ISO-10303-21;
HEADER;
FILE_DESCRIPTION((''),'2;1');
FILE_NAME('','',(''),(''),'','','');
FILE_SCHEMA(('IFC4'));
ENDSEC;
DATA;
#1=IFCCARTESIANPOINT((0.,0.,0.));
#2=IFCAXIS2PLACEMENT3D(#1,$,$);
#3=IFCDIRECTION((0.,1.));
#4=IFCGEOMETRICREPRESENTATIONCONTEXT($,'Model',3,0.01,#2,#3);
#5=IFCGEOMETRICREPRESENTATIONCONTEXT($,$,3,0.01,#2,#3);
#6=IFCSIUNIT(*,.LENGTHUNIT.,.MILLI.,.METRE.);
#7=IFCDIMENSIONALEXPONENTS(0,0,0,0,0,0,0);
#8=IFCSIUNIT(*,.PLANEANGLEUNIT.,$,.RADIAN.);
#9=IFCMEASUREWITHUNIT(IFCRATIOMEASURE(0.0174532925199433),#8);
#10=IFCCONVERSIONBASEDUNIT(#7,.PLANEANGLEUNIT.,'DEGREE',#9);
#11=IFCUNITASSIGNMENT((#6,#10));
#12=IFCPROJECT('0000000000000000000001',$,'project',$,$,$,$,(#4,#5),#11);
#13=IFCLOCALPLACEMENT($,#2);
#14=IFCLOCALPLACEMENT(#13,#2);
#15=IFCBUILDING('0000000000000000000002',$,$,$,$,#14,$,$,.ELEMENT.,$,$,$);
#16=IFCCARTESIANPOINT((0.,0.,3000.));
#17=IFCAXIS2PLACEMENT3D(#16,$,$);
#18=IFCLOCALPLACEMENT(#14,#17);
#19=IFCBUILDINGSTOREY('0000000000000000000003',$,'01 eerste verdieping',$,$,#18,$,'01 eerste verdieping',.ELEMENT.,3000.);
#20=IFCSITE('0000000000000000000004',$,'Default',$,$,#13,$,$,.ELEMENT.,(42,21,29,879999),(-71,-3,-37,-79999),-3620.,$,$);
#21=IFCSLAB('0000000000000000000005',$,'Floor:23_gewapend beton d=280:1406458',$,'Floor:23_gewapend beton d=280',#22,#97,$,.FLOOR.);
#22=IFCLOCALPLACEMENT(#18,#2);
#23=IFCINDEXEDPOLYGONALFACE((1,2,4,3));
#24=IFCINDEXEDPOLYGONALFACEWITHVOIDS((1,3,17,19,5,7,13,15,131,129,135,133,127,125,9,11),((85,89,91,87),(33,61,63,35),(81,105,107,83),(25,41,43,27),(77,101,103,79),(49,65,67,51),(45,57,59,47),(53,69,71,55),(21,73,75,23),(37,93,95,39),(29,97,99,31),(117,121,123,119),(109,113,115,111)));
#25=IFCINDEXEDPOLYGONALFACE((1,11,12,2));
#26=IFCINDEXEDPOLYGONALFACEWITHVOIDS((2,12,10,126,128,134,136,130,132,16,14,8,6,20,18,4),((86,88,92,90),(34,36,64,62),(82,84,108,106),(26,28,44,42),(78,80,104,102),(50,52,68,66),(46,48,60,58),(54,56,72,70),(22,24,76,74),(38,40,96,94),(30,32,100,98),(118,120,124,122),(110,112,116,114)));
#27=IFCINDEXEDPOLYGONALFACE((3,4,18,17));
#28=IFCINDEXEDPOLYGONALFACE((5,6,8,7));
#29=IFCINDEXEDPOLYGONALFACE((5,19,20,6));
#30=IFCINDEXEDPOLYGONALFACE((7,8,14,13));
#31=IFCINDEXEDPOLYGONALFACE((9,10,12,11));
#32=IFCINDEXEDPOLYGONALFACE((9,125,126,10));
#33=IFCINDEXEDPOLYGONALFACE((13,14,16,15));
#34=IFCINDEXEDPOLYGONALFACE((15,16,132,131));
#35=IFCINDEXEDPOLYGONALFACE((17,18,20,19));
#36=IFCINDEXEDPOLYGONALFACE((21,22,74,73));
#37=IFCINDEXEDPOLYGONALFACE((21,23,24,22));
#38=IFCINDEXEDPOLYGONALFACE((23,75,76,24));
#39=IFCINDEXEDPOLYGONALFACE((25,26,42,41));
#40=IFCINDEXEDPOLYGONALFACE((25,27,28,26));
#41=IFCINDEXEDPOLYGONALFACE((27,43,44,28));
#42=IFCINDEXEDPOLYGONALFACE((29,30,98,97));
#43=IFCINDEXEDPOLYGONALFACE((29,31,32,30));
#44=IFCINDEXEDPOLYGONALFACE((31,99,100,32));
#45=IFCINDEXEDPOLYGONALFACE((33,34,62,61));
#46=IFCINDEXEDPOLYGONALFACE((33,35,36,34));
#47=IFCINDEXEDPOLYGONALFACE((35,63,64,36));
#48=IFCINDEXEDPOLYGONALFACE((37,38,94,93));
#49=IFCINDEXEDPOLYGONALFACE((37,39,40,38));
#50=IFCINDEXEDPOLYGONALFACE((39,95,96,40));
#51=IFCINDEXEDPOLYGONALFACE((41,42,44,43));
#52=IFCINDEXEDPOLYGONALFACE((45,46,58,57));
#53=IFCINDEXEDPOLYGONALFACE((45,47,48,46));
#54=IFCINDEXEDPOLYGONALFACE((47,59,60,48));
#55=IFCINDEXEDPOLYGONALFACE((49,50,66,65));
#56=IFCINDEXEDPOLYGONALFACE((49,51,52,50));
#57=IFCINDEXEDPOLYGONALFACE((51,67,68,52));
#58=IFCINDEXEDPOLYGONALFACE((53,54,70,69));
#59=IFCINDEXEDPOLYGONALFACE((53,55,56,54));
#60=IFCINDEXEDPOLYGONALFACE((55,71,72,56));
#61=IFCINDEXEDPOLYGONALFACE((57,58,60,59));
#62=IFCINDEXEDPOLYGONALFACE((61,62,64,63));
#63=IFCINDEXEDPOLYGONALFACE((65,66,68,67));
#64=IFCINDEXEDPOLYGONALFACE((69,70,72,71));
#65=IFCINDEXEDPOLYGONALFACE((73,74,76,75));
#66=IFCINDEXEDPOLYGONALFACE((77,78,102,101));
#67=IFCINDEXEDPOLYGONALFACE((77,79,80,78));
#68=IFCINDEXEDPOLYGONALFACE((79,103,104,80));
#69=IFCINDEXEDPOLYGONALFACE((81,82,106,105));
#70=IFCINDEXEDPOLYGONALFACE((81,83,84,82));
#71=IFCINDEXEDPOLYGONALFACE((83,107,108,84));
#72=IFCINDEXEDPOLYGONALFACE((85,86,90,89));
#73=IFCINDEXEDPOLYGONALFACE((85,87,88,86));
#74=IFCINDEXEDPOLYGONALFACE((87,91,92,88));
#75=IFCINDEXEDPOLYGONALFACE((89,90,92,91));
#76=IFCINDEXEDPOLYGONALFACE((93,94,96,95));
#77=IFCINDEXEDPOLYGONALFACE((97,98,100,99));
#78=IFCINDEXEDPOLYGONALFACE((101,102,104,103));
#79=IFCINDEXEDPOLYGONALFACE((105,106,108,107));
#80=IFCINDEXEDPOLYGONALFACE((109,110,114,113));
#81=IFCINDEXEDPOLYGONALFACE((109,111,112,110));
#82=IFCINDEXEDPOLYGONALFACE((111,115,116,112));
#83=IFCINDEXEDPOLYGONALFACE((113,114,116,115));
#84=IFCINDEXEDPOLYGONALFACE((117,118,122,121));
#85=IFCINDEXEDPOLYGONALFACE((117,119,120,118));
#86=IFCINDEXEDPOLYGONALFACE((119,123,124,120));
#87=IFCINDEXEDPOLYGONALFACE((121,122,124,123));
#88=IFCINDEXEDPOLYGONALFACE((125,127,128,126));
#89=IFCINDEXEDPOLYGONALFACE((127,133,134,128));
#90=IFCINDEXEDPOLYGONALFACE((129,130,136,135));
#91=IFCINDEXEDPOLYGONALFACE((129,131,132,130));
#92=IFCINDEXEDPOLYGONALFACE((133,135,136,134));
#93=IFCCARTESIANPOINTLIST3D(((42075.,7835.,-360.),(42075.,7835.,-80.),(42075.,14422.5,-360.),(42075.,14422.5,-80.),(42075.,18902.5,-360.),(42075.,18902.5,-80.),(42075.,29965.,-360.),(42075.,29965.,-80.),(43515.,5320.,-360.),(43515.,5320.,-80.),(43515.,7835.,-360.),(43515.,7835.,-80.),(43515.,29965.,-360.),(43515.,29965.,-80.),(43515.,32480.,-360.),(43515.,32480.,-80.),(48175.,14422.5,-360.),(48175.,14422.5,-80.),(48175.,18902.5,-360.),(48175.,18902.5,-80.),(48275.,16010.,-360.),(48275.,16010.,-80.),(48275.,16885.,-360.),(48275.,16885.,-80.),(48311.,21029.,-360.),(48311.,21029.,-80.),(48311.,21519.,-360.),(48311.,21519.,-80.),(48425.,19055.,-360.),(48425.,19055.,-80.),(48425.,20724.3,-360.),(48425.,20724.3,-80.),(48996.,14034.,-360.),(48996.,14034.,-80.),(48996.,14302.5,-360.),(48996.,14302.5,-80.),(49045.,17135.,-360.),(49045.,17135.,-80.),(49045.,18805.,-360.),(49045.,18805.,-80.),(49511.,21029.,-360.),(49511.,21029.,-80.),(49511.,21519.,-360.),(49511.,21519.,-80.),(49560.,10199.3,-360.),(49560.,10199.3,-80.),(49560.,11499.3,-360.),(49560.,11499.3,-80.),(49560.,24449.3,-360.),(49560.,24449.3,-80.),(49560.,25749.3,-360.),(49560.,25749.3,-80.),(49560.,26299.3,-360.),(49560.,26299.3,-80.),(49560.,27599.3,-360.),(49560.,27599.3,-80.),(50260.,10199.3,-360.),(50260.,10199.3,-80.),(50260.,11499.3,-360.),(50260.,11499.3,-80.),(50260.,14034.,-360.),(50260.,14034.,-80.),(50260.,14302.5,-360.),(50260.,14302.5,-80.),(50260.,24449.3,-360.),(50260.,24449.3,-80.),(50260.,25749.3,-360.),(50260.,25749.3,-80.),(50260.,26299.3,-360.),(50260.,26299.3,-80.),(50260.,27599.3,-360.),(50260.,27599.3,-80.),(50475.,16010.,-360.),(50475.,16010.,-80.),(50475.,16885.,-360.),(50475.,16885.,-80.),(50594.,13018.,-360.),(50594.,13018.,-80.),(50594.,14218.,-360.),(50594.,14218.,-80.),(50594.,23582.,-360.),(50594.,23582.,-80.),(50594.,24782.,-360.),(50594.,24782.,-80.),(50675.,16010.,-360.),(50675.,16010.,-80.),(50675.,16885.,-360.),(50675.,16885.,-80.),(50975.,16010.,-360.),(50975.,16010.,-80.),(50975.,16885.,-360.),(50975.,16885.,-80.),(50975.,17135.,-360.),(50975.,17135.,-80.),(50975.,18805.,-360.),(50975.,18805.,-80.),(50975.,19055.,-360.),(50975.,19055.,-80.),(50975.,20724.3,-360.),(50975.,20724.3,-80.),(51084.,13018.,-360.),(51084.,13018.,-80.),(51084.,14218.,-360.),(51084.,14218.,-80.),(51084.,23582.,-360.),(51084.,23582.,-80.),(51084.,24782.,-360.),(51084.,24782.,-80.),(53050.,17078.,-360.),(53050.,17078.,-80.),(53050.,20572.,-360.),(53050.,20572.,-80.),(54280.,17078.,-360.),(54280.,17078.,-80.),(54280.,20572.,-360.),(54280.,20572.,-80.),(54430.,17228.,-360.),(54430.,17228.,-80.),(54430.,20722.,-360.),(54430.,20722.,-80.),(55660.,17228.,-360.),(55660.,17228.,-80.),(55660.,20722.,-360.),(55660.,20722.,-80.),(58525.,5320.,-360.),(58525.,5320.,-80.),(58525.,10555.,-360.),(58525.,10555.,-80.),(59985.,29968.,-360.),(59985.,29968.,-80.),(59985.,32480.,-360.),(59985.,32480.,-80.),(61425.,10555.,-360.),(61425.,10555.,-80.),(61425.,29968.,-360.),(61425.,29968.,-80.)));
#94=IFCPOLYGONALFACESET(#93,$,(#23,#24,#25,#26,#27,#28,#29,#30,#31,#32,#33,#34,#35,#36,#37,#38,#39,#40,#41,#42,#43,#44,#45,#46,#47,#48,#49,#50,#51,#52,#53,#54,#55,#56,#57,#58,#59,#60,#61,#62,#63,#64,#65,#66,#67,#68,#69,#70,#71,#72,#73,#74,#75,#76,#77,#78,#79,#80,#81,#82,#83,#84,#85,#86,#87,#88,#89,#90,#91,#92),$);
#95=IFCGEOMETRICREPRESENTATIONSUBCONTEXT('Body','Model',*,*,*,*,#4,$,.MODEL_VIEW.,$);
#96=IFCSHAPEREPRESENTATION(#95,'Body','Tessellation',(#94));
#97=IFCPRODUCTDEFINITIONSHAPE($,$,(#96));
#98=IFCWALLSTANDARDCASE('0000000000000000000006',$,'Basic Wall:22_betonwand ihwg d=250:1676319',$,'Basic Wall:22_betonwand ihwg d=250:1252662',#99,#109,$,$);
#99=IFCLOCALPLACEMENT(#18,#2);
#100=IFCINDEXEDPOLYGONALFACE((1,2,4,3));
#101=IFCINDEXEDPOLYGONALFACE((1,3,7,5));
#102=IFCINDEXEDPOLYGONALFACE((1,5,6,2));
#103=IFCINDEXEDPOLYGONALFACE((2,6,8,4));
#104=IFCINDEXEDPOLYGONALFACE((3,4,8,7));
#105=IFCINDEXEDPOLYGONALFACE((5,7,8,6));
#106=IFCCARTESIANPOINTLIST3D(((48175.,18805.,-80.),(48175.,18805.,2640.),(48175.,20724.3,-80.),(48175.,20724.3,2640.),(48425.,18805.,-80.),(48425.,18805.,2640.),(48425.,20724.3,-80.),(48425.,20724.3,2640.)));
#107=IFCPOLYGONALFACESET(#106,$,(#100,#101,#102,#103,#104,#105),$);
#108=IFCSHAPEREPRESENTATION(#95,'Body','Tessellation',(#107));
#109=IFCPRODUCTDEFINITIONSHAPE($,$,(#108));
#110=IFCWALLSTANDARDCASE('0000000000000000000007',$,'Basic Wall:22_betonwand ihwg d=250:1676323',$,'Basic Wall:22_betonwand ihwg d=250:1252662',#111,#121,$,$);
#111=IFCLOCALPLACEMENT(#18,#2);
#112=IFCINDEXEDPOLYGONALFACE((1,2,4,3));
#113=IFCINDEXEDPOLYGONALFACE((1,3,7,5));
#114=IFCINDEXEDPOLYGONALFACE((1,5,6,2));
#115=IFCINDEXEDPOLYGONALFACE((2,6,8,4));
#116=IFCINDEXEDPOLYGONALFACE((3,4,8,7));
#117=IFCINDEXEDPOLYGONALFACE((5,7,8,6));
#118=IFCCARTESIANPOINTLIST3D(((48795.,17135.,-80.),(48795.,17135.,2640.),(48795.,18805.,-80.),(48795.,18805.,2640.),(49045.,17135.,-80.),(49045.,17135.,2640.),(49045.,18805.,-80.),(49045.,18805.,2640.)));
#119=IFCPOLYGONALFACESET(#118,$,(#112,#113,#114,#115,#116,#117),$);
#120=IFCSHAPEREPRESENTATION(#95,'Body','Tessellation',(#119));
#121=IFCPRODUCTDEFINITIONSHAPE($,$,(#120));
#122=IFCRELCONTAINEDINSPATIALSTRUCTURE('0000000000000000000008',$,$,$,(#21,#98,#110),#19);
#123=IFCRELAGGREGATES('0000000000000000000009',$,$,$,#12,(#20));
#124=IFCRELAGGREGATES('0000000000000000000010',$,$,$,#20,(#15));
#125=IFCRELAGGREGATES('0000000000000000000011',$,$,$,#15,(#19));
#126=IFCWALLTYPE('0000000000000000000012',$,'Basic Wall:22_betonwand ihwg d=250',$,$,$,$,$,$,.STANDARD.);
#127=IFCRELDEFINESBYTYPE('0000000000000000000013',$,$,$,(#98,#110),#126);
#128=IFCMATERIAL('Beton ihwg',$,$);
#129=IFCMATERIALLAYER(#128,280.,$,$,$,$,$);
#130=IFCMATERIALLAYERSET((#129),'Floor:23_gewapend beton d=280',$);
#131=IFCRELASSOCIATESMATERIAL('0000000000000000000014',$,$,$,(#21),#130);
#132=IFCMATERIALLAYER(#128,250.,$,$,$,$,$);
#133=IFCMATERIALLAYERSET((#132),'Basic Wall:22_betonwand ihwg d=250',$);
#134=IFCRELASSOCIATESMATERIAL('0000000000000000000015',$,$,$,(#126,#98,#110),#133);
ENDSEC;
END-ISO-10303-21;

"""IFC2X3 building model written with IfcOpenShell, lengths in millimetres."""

from ifc_helpers import new_model, entity, si_unit, converted_unit, direction, frame, frame_2d, origin, place, context, subcontext, project, spatial, polyline, rectangle, outline, extrude, material, layer, layer_set, layer_usage, type_object, element, save


model = new_model("IFC2X3")

# Units and contexts
model_context = context("Model", 3, precision=0.01, world=origin(), true_north=direction((0.0, 1.0)))
context_of_model = context(None, 3, precision=0.01, world=origin(), true_north=direction((0.0, 1.0)))
body_context = subcontext(model_context, "Body", "Model", "MODEL_VIEW")
ifc_project = project(units=[si_unit("LENGTHUNIT", "METRE", prefix="MILLI"), converted_unit("PLANEANGLEUNIT", "DEGREE", entity("IfcRatioMeasure", 0.0174532925199433), si_unit("PLANEANGLEUNIT", "RADIAN"), dimensions=[0, 0, 0, 0, 0, 0, 0])], contexts=[model_context, context_of_model])

# Site, building, storey
site_placement = place(None, origin())
site = spatial("IfcSite", under=ifc_project, at=site_placement, Name="Default", CompositionType="ELEMENT", RefLatitude=(42, 21, 29, 879999), RefLongitude=(-71, -3, -37, -79999), RefElevation=-3620.0)
building_placement = place(site_placement, origin())
building = spatial("IfcBuilding", under=site, at=building_placement, CompositionType="ELEMENT")
storey_placement = place(building_placement, frame((0.0, 0.0, 3000.0)))
storey = spatial("IfcBuildingStorey", under=building, at=storey_placement, Name="01 eerste verdieping", LongName="01 eerste verdieping", CompositionType="ELEMENT", Elevation=3000.0)

# Slab, openings
ifc_material_1 = material(Name="Beton ihwg")
ifc_layer_1 = layer(ifc_material_1, 280.0)
ifc_layer_set_1 = layer_set([ifc_layer_1], Name="Floor:23_gewapend beton d=280")
ifc_layer_usage_1 = layer_usage(ifc_layer_set_1, "AXIS3", "POSITIVE", 0.0)
slab_1_placement = place(storey_placement, frame((42075.0, 5320.0, -360.0)))
slab_1 = element("IfcSlab", 1, at=slab_1_placement, inside=storey, material=ifc_layer_usage_1, Name="Floor:23_gewapend beton d=280:1406458", ObjectType="Floor:23_gewapend beton d=280", PredefinedType="FLOOR", context=body_context, shape_type="SweptSolid", body=[
    extrude(outline(polyline([(8235.0, 13580.0), (-8235.0, 13580.0), (-8235.0, 11068.0), (-9675.0, 11068.0), (-9675.0, -8345.0), (-6775.0, -8345.0), (-6775.0, -13580.0), (8235.0, -13580.0), (8235.0, -11065.0), (9675.0, -11065.0), (9675.0, -4477.5), (3575.0, -4477.5), (3575.0, 2.5), (9675.0, 2.5), (9675.0, 11065.0), (8235.0, 11065.0), (8235.0, 13580.0)])), frame((9675.0, 13580.0, 280.0), z_axis=(0.0, 0.0, -1.0), x_axis=(-1.0, 0.0, 0.0)), (0.0, 0.0, 1.0), 280.0),
])
opening_1_placement = place(storey_placement, frame((42075.0, 5320.0, -360.0)))
element("IfcOpeningElement", 2, at=opening_1_placement, cuts=slab_1, ObjectType="Opening", context=body_context, shape_type="SweptSolid", body=[
    extrude(rectangle(XDim=1669.3, YDim=2550.0, at=frame_2d((2050.0, 989.6), x_axis=(0.0, 1.0))), frame((9675.0, 13580.0, 280.0), z_axis=(0.0, 0.0, -1.0), x_axis=(-1.0, 0.0, 0.0)), (0.0, 0.0, 1.0), 280.0),
])
opening_2_placement = place(storey_placement, frame((42075.0, 5320.0, -360.0)))
element("IfcOpeningElement", 3, at=opening_2_placement, cuts=slab_1, ObjectType="Opening", context=body_context, shape_type="SweptSolid", body=[
    extrude(rectangle(XDim=1670.0, YDim=1930.0, at=frame_2d((1740.0, -930.0), x_axis=(0.0, 1.0))), frame((9675.0, 13580.0, 280.0), z_axis=(0.0, 0.0, -1.0), x_axis=(-1.0, 0.0, 0.0)), (0.0, 0.0, 1.0), 280.0),
])
opening_3_placement = place(storey_placement, frame((42075.0, 5320.0, -360.0)))
element("IfcOpeningElement", 4, at=opening_3_placement, cuts=slab_1, ObjectType="Opening", context=body_context, shape_type="SweptSolid", body=[
    extrude(rectangle(XDim=1300.0, YDim=700.0, at=frame_2d((1840.0, 8049.3), x_axis=(0.0, 1.0))), frame((9675.0, 13580.0, 280.0), z_axis=(0.0, 0.0, -1.0), x_axis=(-1.0, 0.0, 0.0)), (0.0, 0.0, 1.0), 280.0),
])
opening_4_placement = place(storey_placement, frame((42075.0, 5320.0, -360.0)))
element("IfcOpeningElement", 5, at=opening_4_placement, cuts=slab_1, ObjectType="Opening", context=body_context, shape_type="SweptSolid", body=[
    extrude(rectangle(XDim=1300.0, YDim=700.0, at=frame_2d((1840.0, 6199.3), x_axis=(0.0, 1.0))), frame((9675.0, 13580.0, 280.0), z_axis=(0.0, 0.0, -1.0), x_axis=(-1.0, 0.0, 0.0)), (0.0, 0.0, 1.0), 280.0),
])
opening_5_placement = place(storey_placement, frame((42075.0, 5320.0, -360.0)))
element("IfcOpeningElement", 6, at=opening_5_placement, cuts=slab_1, ObjectType="Opening", context=body_context, shape_type="SweptSolid", body=[
    extrude(rectangle(XDim=1300.0, YDim=700.0, at=frame_2d((1840.0, -8050.7), x_axis=(0.0, 1.0))), frame((9675.0, 13580.0, 280.0), z_axis=(0.0, 0.0, -1.0), x_axis=(-1.0, 0.0, 0.0)), (0.0, 0.0, 1.0), 280.0),
])
opening_6_placement = place(storey_placement, frame((42075.0, 5320.0, -360.0)))
element("IfcOpeningElement", 7, at=opening_6_placement, cuts=slab_1, ObjectType="Opening", context=body_context, shape_type="SweptSolid", body=[
    extrude(rectangle(XDim=875.0, YDim=2200.0, at=frame_2d((2375.0, -2452.5), x_axis=(0.0, 1.0))), frame((9675.0, 13580.0, 280.0), z_axis=(0.0, 0.0, -1.0), x_axis=(-1.0, 0.0, 0.0)), (0.0, 0.0, 1.0), 280.0),
])
opening_7_placement = place(storey_placement, frame((42075.0, 5320.0, -360.0)))
element("IfcOpeningElement", 8, at=opening_7_placement, cuts=slab_1, ObjectType="Opening", context=body_context, shape_type="SweptSolid", body=[
    extrude(rectangle(XDim=875.0, YDim=300.0, at=frame_2d((925.0, -2452.5), x_axis=(0.0, 1.0))), frame((9675.0, 13580.0, 280.0), z_axis=(0.0, 0.0, -1.0), x_axis=(-1.0, 0.0, 0.0)), (0.0, 0.0, 1.0), 280.0),
])
opening_8_placement = place(storey_placement, frame((42075.0, 5320.0, -360.0)))
element("IfcOpeningElement", 9, at=opening_8_placement, cuts=slab_1, ObjectType="Opening", context=body_context, shape_type="SweptSolid", body=[
    extrude(rectangle(XDim=3494.0, YDim=1230.0, at=frame_2d((-3295.0, 75.0), x_axis=(0.0, 1.0))), frame((9675.0, 13580.0, 280.0), z_axis=(0.0, 0.0, -1.0), x_axis=(-1.0, 0.0, 0.0)), (0.0, 0.0, 1.0), 280.0),
])
opening_9_placement = place(storey_placement, frame((42075.0, 5320.0, -360.0)))
element("IfcOpeningElement", 10, at=opening_9_placement, cuts=slab_1, ObjectType="Opening", context=body_context, shape_type="SweptSolid", body=[
    extrude(rectangle(XDim=3494.0, YDim=1230.0, at=frame_2d((-1915.0, -75.0), x_axis=(0.0, 1.0))), frame((9675.0, 13580.0, 280.0), z_axis=(0.0, 0.0, -1.0), x_axis=(-1.0, 0.0, 0.0)), (0.0, 0.0, 1.0), 280.0),
])
opening_10_placement = place(storey_placement, frame((42075.0, 5320.0, -360.0)))
element("IfcOpeningElement", 11, at=opening_10_placement, cuts=slab_1, ObjectType="Opening", context=body_context, shape_type="SweptSolid", body=[
    extrude(rectangle(XDim=490.0, YDim=1200.0, at=frame_2d((911.0, 5282.0), x_axis=(-1.0, 0.0))), frame((9675.0, 13580.0, 280.0), z_axis=(0.0, 0.0, -1.0), x_axis=(-1.0, 0.0, 0.0)), (0.0, 0.0, 1.0), 280.0),
])
opening_11_placement = place(storey_placement, frame((42075.0, 5320.0, -360.0)))
element("IfcOpeningElement", 12, at=opening_11_placement, cuts=slab_1, ObjectType="Opening", context=body_context, shape_type="SweptSolid", body=[
    extrude(rectangle(XDim=490.0, YDim=1200.0, at=frame_2d((2839.0, 2374.0), x_axis=(0.0, 1.0))), frame((9675.0, 13580.0, 280.0), z_axis=(0.0, 0.0, -1.0), x_axis=(-1.0, 0.0, 0.0)), (0.0, 0.0, 1.0), 280.0),
])
opening_12_placement = place(storey_placement, frame((42075.0, 5320.0, -360.0)))
element("IfcOpeningElement", 13, at=opening_12_placement, cuts=slab_1, ObjectType="Opening", context=body_context, shape_type="SweptSolid", body=[
    extrude(rectangle(XDim=490.0, YDim=1200.0, at=frame_2d((911.0, -5282.0), x_axis=(-1.0, 0.0))), frame((9675.0, 13580.0, 280.0), z_axis=(0.0, 0.0, -1.0), x_axis=(-1.0, 0.0, 0.0)), (0.0, 0.0, 1.0), 280.0),
])
opening_13_placement = place(storey_placement, frame((42075.0, 5320.0, -360.0)))
element("IfcOpeningElement", 14, at=opening_13_placement, cuts=slab_1, ObjectType="Opening", context=body_context, shape_type="SweptSolid", body=[
    extrude(rectangle(XDim=268.5, YDim=1264.0, at=frame_2d((2122.0, -4731.7), x_axis=(0.0, 1.0))), frame((9675.0, 13580.0, 280.0), z_axis=(0.0, 0.0, -1.0), x_axis=(-1.0, 0.0, 0.0)), (0.0, 0.0, 1.0), 280.0),
])

# Shared definitions
ifc_layer_2 = layer(ifc_material_1, 250.0)
ifc_layer_set_2 = layer_set([ifc_layer_2], Name="Basic Wall:22_betonwand ihwg d=250")
wall_type_1 = type_object("IfcWallType", Name="Basic Wall:22_betonwand ihwg d=250", PredefinedType="STANDARD", material=ifc_layer_set_2)

# Walls
ifc_layer_usage_2 = layer_usage(ifc_layer_set_2, "AXIS2", "POSITIVE", -125.0)
wall_1_placement = place(storey_placement, frame((48300.0, 20724.3, -80.0), z_axis=(0.0, 0.0, 1.0), x_axis=(0.0, -1.0, 0.0)))
element("IfcWallStandardCase", 15, at=wall_1_placement, inside=storey, type_object=wall_type_1, material=ifc_layer_usage_2, Name="Basic Wall:22_betonwand ihwg d=250:1676319", ObjectType="Basic Wall:22_betonwand ihwg d=250:1252662", context=body_context, shape_type="SweptSolid", body=[
    extrude(rectangle(XDim=1919.3, YDim=250.0, at=frame_2d((959.6, 0.0), x_axis=(-1.0, 0.0))), origin(), (0.0, 0.0, 1.0), 2720.0),
])
ifc_layer_usage_3 = layer_usage(ifc_layer_set_2, "AXIS2", "POSITIVE", -125.0)
wall_2_placement = place(storey_placement, frame((48920.0, 18805.0, -80.0), z_axis=(0.0, 0.0, 1.0), x_axis=(0.0, -1.0, 0.0)))
element("IfcWallStandardCase", 16, at=wall_2_placement, inside=storey, type_object=wall_type_1, material=ifc_layer_usage_3, Name="Basic Wall:22_betonwand ihwg d=250:1676323", ObjectType="Basic Wall:22_betonwand ihwg d=250:1252662", context=body_context, shape_type="SweptSolid", body=[
    extrude(rectangle(XDim=1670.0, YDim=250.0, at=frame_2d((835.0, 0.0), x_axis=(-1.0, 0.0))), origin(), (0.0, 0.0, 1.0), 2720.0),
])

save(model, "model.ifc")
